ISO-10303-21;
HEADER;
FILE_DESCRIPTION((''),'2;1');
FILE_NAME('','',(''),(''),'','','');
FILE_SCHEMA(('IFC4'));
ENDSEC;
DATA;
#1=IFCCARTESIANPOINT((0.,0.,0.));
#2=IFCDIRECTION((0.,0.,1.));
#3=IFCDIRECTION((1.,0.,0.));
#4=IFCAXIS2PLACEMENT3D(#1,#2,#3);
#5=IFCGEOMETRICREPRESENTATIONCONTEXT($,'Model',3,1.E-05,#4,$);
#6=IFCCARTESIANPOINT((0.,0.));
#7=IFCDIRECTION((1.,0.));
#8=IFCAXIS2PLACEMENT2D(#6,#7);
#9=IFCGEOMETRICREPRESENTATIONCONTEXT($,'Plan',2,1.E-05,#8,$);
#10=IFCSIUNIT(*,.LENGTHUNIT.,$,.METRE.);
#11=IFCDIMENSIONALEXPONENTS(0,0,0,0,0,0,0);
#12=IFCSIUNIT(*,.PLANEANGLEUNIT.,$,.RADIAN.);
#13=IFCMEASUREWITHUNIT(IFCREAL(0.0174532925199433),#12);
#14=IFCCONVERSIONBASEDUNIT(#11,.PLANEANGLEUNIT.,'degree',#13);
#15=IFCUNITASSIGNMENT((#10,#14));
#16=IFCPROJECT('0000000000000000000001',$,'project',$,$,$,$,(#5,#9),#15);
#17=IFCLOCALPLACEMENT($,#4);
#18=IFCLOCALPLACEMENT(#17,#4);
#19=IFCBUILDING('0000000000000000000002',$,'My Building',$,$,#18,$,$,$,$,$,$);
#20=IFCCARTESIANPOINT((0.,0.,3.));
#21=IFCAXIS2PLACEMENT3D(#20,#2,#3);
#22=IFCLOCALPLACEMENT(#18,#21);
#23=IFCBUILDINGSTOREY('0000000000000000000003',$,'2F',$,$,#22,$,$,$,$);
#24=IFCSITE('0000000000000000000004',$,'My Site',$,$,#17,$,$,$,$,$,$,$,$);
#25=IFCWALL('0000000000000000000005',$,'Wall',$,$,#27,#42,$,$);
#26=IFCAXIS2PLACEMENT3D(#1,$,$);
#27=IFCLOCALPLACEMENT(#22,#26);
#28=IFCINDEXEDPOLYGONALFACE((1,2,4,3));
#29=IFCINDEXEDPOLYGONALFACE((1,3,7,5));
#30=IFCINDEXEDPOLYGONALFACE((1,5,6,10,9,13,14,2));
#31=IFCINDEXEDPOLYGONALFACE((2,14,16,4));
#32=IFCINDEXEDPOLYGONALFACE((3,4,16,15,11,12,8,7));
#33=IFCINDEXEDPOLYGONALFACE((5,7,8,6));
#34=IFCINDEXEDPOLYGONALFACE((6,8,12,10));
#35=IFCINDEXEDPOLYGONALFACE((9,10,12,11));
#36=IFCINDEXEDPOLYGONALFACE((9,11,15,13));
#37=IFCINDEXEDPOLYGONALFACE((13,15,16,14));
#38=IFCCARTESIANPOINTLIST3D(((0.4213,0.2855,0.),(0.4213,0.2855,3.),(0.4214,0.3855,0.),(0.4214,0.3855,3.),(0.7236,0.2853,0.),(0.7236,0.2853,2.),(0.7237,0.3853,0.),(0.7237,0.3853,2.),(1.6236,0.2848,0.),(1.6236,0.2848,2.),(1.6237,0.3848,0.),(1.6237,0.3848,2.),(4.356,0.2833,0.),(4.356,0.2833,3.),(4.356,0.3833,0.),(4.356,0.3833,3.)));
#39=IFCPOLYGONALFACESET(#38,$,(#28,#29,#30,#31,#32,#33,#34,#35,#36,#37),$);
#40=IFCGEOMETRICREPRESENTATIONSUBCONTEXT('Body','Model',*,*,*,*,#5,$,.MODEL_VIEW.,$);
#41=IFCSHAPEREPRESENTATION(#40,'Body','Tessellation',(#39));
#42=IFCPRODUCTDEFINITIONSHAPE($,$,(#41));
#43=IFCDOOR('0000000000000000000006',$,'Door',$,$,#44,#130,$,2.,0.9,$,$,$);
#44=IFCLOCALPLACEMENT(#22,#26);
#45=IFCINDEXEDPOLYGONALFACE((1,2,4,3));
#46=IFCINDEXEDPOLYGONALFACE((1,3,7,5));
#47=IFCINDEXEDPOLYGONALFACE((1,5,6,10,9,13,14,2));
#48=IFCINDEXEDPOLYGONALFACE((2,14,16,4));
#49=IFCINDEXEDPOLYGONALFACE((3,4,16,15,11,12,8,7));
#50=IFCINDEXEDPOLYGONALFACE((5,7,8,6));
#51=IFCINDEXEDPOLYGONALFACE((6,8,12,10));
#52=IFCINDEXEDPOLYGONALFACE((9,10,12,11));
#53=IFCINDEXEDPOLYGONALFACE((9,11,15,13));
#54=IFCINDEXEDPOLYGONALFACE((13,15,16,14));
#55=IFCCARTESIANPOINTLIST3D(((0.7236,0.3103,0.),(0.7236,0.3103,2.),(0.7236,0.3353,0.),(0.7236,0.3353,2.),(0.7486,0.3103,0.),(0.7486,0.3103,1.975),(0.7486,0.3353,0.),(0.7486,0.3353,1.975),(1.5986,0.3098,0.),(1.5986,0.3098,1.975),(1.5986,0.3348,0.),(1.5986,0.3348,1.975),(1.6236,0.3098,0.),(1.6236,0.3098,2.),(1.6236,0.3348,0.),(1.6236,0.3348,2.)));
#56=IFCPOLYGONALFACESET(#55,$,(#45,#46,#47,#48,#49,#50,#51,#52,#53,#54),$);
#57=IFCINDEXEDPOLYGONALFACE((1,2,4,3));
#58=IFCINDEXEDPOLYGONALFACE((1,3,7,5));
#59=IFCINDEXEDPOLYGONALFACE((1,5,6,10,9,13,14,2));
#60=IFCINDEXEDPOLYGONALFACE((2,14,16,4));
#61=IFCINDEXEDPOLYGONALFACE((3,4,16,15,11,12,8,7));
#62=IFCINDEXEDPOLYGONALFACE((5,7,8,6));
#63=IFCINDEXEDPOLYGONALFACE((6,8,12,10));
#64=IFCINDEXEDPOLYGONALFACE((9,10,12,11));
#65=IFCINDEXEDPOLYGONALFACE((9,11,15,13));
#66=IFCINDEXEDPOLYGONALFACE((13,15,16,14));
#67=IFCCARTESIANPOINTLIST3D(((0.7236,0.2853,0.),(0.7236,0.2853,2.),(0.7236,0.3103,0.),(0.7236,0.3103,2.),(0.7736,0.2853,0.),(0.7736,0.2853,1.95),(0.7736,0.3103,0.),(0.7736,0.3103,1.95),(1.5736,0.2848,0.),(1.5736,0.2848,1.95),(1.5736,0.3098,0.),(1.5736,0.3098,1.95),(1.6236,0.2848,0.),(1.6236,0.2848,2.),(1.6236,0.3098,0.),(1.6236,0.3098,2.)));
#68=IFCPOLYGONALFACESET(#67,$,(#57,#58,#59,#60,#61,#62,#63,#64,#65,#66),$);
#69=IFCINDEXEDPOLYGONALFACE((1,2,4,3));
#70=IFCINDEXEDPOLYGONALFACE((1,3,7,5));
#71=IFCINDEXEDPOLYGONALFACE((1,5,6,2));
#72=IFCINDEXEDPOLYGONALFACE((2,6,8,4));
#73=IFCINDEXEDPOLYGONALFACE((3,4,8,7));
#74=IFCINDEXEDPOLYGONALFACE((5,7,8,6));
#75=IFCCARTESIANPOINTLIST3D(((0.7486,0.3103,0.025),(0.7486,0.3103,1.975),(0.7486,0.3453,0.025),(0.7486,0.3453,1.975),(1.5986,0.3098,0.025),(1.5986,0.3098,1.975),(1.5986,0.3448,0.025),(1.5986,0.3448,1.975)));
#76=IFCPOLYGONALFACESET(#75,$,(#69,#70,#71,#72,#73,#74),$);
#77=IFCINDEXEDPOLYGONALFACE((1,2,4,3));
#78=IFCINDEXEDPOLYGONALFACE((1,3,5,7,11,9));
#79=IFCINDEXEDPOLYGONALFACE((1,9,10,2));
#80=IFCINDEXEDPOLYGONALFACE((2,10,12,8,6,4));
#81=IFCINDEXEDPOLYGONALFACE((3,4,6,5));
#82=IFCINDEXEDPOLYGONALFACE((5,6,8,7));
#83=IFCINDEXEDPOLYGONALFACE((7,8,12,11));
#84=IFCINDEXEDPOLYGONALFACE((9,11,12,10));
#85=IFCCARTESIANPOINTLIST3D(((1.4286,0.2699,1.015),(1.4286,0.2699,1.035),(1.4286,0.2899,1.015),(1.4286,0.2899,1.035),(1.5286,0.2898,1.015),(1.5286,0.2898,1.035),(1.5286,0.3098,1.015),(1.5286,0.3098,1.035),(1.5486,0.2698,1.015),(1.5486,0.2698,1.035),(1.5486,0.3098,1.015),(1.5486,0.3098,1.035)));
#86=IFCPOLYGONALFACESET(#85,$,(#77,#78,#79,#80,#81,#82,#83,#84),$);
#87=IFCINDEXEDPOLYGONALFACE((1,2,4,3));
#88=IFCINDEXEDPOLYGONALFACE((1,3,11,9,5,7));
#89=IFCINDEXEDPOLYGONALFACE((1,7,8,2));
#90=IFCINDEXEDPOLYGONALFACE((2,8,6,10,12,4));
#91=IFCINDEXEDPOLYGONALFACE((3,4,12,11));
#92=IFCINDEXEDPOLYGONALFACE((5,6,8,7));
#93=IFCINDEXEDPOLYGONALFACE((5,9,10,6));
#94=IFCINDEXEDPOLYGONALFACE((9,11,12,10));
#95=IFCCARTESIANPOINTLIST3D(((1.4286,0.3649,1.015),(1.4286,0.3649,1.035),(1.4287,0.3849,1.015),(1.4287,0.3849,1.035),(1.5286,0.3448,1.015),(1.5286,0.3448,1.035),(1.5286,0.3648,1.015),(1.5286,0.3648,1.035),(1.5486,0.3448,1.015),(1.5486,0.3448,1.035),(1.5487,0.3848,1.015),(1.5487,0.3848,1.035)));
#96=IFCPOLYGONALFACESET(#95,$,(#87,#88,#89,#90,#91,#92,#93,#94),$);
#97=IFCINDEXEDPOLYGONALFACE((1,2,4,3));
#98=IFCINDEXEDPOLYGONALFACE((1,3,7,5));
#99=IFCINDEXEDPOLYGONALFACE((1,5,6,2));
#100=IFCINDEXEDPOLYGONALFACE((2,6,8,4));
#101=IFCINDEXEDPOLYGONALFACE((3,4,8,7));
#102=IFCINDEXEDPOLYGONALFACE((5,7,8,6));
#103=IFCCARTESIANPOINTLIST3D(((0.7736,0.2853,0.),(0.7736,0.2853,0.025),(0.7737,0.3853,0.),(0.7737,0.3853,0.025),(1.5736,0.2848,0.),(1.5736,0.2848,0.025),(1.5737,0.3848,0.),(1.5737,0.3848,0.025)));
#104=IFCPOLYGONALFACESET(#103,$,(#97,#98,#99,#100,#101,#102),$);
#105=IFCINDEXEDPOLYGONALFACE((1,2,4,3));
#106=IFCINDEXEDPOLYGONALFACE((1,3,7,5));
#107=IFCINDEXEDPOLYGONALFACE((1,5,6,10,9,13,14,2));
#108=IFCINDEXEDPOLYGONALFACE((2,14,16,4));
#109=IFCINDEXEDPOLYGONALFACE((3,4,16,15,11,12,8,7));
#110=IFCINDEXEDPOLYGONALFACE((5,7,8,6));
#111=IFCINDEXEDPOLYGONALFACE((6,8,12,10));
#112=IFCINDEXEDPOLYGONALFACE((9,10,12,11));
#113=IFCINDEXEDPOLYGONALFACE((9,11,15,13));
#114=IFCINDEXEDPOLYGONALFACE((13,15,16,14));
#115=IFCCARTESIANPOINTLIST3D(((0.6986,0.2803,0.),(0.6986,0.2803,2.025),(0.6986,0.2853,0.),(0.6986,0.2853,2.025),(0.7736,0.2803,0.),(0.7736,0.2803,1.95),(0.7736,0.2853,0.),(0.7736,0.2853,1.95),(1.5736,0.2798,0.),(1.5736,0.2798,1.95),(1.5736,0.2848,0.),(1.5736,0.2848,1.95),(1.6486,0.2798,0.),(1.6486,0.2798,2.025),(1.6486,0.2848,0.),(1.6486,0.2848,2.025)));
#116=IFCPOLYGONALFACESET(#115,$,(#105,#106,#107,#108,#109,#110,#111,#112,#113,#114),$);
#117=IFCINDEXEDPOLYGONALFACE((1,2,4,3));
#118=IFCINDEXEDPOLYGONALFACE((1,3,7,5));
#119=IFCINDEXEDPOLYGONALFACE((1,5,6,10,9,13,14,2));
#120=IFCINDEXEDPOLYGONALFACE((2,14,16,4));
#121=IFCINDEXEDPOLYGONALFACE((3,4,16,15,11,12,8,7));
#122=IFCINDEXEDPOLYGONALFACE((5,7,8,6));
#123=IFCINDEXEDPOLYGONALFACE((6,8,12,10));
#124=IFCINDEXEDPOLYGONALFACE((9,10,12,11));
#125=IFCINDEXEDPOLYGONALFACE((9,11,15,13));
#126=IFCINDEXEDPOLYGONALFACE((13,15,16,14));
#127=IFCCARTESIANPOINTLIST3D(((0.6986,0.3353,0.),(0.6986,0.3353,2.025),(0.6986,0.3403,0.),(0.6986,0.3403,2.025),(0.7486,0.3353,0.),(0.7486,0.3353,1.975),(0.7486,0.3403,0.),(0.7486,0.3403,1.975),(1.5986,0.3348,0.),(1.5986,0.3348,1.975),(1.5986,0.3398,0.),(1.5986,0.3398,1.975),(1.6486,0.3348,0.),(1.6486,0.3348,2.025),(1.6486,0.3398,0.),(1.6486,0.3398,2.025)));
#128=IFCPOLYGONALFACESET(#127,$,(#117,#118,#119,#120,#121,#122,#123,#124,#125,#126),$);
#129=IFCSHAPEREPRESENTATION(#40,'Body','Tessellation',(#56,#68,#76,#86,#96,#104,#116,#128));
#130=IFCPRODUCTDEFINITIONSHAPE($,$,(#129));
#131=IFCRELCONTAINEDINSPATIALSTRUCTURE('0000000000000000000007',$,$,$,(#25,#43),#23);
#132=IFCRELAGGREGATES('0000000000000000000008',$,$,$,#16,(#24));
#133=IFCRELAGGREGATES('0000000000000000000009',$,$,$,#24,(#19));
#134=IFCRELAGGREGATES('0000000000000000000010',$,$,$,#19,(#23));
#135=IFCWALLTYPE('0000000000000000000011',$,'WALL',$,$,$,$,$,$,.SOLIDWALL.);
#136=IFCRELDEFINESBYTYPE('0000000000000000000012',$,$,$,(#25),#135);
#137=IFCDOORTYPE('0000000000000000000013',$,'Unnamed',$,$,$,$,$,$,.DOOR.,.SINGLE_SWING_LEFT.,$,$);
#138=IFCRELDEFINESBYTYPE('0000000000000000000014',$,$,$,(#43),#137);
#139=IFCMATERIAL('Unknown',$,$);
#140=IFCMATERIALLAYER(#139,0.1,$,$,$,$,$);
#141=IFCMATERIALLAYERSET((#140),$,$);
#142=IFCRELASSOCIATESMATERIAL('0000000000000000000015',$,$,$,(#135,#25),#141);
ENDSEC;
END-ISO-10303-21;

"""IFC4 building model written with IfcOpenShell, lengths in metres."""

from ifc_helpers import new_model, entity, si_unit, converted_unit, frame, origin_with_axes, origin_2d_with_axis, place, context, subcontext, project, spatial, line, indexed_curve, outline, extrude, shape, source, transform, mapped, material, layer, layer_set, layer_usage, type_object, type_shapes, element, fill, save


model = new_model("IFC4")

# Units and contexts
model_context = context("Model", 3, precision=1e-05, world=origin_with_axes())
plan_context = context("Plan", 2, precision=1e-05, world=origin_2d_with_axis())
body_context_1 = subcontext(model_context, "Body", "Model", "MODEL_VIEW")
body_context_2 = subcontext(plan_context, "Body", "Plan", "PLAN_VIEW")
ifc_project = project(units=[si_unit("LENGTHUNIT", "METRE"), converted_unit("PLANEANGLEUNIT", "degree", entity("IfcReal", 0.0174532925199433), si_unit("PLANEANGLEUNIT", "RADIAN"), dimensions=[0, 0, 0, 0, 0, 0, 0])], contexts=[model_context, plan_context])

# Site, building, storey
site_placement = place(None, origin_with_axes())
site = spatial("IfcSite", under=ifc_project, at=site_placement, Name="My Site")
building_placement = place(site_placement, origin_with_axes())
building = spatial("IfcBuilding", under=site, at=building_placement, Name="My Building")
storey_placement = place(building_placement, frame((0.0, 0.0, 3.0), z_axis=(0.0, 0.0, 1.0), x_axis=(1.0, 0.0, 0.0)))
storey = spatial("IfcBuildingStorey", under=building, at=storey_placement, Name="2F")

# Shared definitions
ifc_material = material(Name="Unknown")
ifc_layer = layer(ifc_material, 0.1)
ifc_layer_set = layer_set([ifc_layer])
wall_type = type_object("IfcWallType", Name="WALL", PredefinedType="SOLIDWALL", material=ifc_layer_set)

# Shared definitions
shared_shape_1 = source(origin_with_axes(), body_context_1, "Body", "SweptSolid", [
    extrude(outline(indexed_curve([(0.0, 0.0), (0.9, 0.0), (0.9, 2.0), (0.0, 2.0)], segments=[line(1, 2, 3, 4, 1)])), frame((0.0, -0.6, 0.0), z_axis=(0.0, -1.0, 0.0), x_axis=(1.0, 0.0, 0.0)), (0.0, 0.0, -1.0), 1.2),
])
door_type = type_object("IfcDoorType", Name="Unnamed", OperationType="SINGLE_SWING_LEFT", PredefinedType="DOOR")
shared_shape_2 = source(origin_with_axes(), body_context_1, "Body", "SweptSolid", [
    extrude(outline(indexed_curve([(0.0, 0.0), (0.0, 2.0), (0.9, 2.0), (0.9, 0.0), (0.875, 0.0), (0.875, 1.975), (0.025, 1.975), (0.025, 0.0)], segments=[line(1, 2, 3, 4, 5, 6, 7, 8, 1)])), frame((0.0, 0.025, 0.0), z_axis=(0.0, -1.0, 0.0), x_axis=(1.0, 0.0, 0.0)), (0.0, 0.0, -1.0), 0.025),
    extrude(outline(indexed_curve([(0.0, 0.0), (0.0, 2.0), (0.9, 2.0), (0.9, 0.0), (0.85, 0.0), (0.85, 1.95), (0.05, 1.95), (0.05, 0.0)], segments=[line(1, 2, 3, 4, 5, 6, 7, 8, 1)])), frame((0.0, 0.0, 0.0), z_axis=(0.0, -1.0, 0.0), x_axis=(1.0, 0.0, 0.0)), (0.0, 0.0, -1.0), 0.025),
    extrude(outline(indexed_curve([(0.0, 0.0), (0.85, 0.0), (0.85, 0.035), (0.0, 0.035)], segments=[line(1, 2, 3, 4, 1)])), frame((0.025, 0.025, 0.025), z_axis=(0.0, 0.0, 1.0), x_axis=(1.0, 0.0, 0.0)), (0.0, 0.0, 1.0), 1.95),
    extrude(outline(indexed_curve([(0.0, 0.0), (0.0, -0.04), (-0.12, -0.04), (-0.12, -0.02), (-0.02, -0.02), (-0.02, 0.0)], segments=[line(1, 2, 3, 4, 5, 6, 1)])), frame((0.825, 0.025, 1.015), z_axis=(0.0, 0.0, 1.0), x_axis=(1.0, 0.0, 0.0)), (0.0, 0.0, 1.0), 0.02),
    extrude(outline(indexed_curve([(0.0, 0.0), (0.0, 0.04), (-0.12, 0.04), (-0.12, 0.02), (-0.02, 0.02), (-0.02, 0.0)], segments=[line(1, 2, 3, 4, 5, 6, 1)])), frame((0.825, 0.06, 1.015), z_axis=(0.0, 0.0, 1.0), x_axis=(1.0, 0.0, 0.0)), (0.0, 0.0, 1.0), 0.02),
    extrude(outline(indexed_curve([(0.0, 0.0), (0.8, 0.0), (0.8, 0.1), (0.0, 0.1)], segments=[line(1, 2, 3, 4, 1)])), frame((0.05, 0.0, 0.0), z_axis=(0.0, 0.0, 1.0), x_axis=(1.0, 0.0, 0.0)), (0.0, 0.0, 1.0), 0.025),
    extrude(outline(indexed_curve([(0.0, 0.0), (0.0, 2.025), (0.95, 2.025), (0.95, 0.0), (0.875, 0.0), (0.875, 1.95), (0.075, 1.95), (0.075, 0.0)], segments=[line(1, 2, 3, 4, 5, 6, 7, 8, 1)])), frame((-0.025, -0.005, 0.0), z_axis=(0.0, -1.0, 0.0), x_axis=(1.0, 0.0, 0.0)), (0.0, 0.0, -1.0), 0.005),
    extrude(outline(indexed_curve([(0.0, 0.0), (0.0, 2.025), (0.95, 2.025), (0.95, 0.0), (0.9, 0.0), (0.9, 1.975), (0.05, 1.975), (0.05, 0.0)], segments=[line(1, 2, 3, 4, 5, 6, 7, 8, 1)])), frame((-0.025, 0.05, 0.0), z_axis=(0.0, -1.0, 0.0), x_axis=(1.0, 0.0, 0.0)), (0.0, 0.0, -1.0), 0.005),
])
shared_shape_3 = source(origin_with_axes(), body_context_2, "Body", "Curve2D", [
    entity("IfcIndexedPolyCurve", entity("IfcCartesianPointList2D", [[0.0, 0.0], [0.0, 0.05], [0.025, 0.05], [0.025, 0.025], [0.05, 0.025], [0.05, 0.0]]), [entity("IfcLineIndex", [1, 2, 3, 4, 5, 6, 1])]),
    entity("IfcIndexedPolyCurve", entity("IfcCartesianPointList2D", [[0.9, 0.0], [0.9, 0.05], [0.875, 0.05], [0.875, 0.025], [0.85, 0.025], [0.85, 0.0]]), [entity("IfcLineIndex", [1, 2, 3, 4, 5, 6, 1])]),
    entity("IfcTrimmedCurve", entity("IfcEllipse", entity("IfcAxis2Placement2D", entity("IfcCartesianPoint", [0.06, 0.05]), entity("IfcDirection", [1.0, 0.0])), 0.815, 0.85), [entity("IfcCartesianPoint", [0.875, 0.05])], [entity("IfcCartesianPoint", [0.06, 0.9])], True, "CARTESIAN"),
    entity("IfcIndexedPolyCurve", entity("IfcCartesianPointList2D", [[0.025, 0.05], [0.06, 0.05], [0.06, 0.9], [0.025, 0.9]]), [entity("IfcLineIndex", [1, 2, 3, 4, 1])]),
])
type_shapes(door_type, [shared_shape_2, shared_shape_3])

# Wall, opening, door
ifc_layer_usage_1 = layer_usage(ifc_layer_set, "AXIS2", "POSITIVE", 0.0)
wall_1_placement = place(storey_placement, frame((0.4213, 0.2855, 0.0), z_axis=(0.0, 0.0, 1.0), x_axis=(1.0, -0.000561, 0.0)))
wall_1 = element("IfcWall", 1, at=wall_1_placement, inside=storey, type_object=wall_type, material=ifc_layer_usage_1, Name="Wall", context=body_context_1, shape_type="SweptSolid", body=[
    extrude(outline(indexed_curve([(0.0, 0.0), (0.0, 0.1), (3.9347, 0.1), (3.9347, 0.0)], segments=[line(1, 2, 3, 4, 1)])), origin_with_axes(), (0.0, 0.0, 1.0), 3.0),
])
opening_1_placement = place(wall_1_placement, frame((0.3023, 0.0, 0.0), z_axis=(0.0, 0.0, 1.0), x_axis=(1.0, 0.0, 0.0)))
opening_1 = element("IfcOpeningElement", 2, at=opening_1_placement, cuts=wall_1, PredefinedType="OPENING", context=body_context_1, shape_type="MappedRepresentation", body=[
    mapped(shared_shape_1, transform((0.0, 0.0, 0.0), x_axis=(1.0, 0.0, 0.0), y_axis=(0.0, 1.0, 0.0), z_axis=(0.0, 0.0, 1.0), scale=1.0)),
])
door_1_placement = place(opening_1_placement, frame((0.0, 0.0, 0.0), z_axis=(0.0, 0.0, 1.0), x_axis=(1.0, 0.0, 0.0)))
door_1 = element("IfcDoor", 3, at=door_1_placement, inside=storey, type_object=door_type, Name="Door", OverallHeight=2.0, OverallWidth=0.9, shapes=[
    shape(body_context_1, "Body", "MappedRepresentation", [mapped(shared_shape_2, transform((0.0, 0.0, 0.0), x_axis=(1.0, 0.0, 0.0), y_axis=(0.0, 1.0, 0.0), z_axis=(0.0, 0.0, 1.0), scale=1.0))]),
    shape(body_context_2, "Body", "MappedRepresentation", [mapped(shared_shape_3, transform((0.0, 0.0, 0.0), x_axis=(1.0, 0.0, 0.0), y_axis=(0.0, 1.0, 0.0), z_axis=(0.0, 0.0, 1.0), scale=1.0))]),
])
fill(opening_1, door_1)

save(model, "model.ifc")
